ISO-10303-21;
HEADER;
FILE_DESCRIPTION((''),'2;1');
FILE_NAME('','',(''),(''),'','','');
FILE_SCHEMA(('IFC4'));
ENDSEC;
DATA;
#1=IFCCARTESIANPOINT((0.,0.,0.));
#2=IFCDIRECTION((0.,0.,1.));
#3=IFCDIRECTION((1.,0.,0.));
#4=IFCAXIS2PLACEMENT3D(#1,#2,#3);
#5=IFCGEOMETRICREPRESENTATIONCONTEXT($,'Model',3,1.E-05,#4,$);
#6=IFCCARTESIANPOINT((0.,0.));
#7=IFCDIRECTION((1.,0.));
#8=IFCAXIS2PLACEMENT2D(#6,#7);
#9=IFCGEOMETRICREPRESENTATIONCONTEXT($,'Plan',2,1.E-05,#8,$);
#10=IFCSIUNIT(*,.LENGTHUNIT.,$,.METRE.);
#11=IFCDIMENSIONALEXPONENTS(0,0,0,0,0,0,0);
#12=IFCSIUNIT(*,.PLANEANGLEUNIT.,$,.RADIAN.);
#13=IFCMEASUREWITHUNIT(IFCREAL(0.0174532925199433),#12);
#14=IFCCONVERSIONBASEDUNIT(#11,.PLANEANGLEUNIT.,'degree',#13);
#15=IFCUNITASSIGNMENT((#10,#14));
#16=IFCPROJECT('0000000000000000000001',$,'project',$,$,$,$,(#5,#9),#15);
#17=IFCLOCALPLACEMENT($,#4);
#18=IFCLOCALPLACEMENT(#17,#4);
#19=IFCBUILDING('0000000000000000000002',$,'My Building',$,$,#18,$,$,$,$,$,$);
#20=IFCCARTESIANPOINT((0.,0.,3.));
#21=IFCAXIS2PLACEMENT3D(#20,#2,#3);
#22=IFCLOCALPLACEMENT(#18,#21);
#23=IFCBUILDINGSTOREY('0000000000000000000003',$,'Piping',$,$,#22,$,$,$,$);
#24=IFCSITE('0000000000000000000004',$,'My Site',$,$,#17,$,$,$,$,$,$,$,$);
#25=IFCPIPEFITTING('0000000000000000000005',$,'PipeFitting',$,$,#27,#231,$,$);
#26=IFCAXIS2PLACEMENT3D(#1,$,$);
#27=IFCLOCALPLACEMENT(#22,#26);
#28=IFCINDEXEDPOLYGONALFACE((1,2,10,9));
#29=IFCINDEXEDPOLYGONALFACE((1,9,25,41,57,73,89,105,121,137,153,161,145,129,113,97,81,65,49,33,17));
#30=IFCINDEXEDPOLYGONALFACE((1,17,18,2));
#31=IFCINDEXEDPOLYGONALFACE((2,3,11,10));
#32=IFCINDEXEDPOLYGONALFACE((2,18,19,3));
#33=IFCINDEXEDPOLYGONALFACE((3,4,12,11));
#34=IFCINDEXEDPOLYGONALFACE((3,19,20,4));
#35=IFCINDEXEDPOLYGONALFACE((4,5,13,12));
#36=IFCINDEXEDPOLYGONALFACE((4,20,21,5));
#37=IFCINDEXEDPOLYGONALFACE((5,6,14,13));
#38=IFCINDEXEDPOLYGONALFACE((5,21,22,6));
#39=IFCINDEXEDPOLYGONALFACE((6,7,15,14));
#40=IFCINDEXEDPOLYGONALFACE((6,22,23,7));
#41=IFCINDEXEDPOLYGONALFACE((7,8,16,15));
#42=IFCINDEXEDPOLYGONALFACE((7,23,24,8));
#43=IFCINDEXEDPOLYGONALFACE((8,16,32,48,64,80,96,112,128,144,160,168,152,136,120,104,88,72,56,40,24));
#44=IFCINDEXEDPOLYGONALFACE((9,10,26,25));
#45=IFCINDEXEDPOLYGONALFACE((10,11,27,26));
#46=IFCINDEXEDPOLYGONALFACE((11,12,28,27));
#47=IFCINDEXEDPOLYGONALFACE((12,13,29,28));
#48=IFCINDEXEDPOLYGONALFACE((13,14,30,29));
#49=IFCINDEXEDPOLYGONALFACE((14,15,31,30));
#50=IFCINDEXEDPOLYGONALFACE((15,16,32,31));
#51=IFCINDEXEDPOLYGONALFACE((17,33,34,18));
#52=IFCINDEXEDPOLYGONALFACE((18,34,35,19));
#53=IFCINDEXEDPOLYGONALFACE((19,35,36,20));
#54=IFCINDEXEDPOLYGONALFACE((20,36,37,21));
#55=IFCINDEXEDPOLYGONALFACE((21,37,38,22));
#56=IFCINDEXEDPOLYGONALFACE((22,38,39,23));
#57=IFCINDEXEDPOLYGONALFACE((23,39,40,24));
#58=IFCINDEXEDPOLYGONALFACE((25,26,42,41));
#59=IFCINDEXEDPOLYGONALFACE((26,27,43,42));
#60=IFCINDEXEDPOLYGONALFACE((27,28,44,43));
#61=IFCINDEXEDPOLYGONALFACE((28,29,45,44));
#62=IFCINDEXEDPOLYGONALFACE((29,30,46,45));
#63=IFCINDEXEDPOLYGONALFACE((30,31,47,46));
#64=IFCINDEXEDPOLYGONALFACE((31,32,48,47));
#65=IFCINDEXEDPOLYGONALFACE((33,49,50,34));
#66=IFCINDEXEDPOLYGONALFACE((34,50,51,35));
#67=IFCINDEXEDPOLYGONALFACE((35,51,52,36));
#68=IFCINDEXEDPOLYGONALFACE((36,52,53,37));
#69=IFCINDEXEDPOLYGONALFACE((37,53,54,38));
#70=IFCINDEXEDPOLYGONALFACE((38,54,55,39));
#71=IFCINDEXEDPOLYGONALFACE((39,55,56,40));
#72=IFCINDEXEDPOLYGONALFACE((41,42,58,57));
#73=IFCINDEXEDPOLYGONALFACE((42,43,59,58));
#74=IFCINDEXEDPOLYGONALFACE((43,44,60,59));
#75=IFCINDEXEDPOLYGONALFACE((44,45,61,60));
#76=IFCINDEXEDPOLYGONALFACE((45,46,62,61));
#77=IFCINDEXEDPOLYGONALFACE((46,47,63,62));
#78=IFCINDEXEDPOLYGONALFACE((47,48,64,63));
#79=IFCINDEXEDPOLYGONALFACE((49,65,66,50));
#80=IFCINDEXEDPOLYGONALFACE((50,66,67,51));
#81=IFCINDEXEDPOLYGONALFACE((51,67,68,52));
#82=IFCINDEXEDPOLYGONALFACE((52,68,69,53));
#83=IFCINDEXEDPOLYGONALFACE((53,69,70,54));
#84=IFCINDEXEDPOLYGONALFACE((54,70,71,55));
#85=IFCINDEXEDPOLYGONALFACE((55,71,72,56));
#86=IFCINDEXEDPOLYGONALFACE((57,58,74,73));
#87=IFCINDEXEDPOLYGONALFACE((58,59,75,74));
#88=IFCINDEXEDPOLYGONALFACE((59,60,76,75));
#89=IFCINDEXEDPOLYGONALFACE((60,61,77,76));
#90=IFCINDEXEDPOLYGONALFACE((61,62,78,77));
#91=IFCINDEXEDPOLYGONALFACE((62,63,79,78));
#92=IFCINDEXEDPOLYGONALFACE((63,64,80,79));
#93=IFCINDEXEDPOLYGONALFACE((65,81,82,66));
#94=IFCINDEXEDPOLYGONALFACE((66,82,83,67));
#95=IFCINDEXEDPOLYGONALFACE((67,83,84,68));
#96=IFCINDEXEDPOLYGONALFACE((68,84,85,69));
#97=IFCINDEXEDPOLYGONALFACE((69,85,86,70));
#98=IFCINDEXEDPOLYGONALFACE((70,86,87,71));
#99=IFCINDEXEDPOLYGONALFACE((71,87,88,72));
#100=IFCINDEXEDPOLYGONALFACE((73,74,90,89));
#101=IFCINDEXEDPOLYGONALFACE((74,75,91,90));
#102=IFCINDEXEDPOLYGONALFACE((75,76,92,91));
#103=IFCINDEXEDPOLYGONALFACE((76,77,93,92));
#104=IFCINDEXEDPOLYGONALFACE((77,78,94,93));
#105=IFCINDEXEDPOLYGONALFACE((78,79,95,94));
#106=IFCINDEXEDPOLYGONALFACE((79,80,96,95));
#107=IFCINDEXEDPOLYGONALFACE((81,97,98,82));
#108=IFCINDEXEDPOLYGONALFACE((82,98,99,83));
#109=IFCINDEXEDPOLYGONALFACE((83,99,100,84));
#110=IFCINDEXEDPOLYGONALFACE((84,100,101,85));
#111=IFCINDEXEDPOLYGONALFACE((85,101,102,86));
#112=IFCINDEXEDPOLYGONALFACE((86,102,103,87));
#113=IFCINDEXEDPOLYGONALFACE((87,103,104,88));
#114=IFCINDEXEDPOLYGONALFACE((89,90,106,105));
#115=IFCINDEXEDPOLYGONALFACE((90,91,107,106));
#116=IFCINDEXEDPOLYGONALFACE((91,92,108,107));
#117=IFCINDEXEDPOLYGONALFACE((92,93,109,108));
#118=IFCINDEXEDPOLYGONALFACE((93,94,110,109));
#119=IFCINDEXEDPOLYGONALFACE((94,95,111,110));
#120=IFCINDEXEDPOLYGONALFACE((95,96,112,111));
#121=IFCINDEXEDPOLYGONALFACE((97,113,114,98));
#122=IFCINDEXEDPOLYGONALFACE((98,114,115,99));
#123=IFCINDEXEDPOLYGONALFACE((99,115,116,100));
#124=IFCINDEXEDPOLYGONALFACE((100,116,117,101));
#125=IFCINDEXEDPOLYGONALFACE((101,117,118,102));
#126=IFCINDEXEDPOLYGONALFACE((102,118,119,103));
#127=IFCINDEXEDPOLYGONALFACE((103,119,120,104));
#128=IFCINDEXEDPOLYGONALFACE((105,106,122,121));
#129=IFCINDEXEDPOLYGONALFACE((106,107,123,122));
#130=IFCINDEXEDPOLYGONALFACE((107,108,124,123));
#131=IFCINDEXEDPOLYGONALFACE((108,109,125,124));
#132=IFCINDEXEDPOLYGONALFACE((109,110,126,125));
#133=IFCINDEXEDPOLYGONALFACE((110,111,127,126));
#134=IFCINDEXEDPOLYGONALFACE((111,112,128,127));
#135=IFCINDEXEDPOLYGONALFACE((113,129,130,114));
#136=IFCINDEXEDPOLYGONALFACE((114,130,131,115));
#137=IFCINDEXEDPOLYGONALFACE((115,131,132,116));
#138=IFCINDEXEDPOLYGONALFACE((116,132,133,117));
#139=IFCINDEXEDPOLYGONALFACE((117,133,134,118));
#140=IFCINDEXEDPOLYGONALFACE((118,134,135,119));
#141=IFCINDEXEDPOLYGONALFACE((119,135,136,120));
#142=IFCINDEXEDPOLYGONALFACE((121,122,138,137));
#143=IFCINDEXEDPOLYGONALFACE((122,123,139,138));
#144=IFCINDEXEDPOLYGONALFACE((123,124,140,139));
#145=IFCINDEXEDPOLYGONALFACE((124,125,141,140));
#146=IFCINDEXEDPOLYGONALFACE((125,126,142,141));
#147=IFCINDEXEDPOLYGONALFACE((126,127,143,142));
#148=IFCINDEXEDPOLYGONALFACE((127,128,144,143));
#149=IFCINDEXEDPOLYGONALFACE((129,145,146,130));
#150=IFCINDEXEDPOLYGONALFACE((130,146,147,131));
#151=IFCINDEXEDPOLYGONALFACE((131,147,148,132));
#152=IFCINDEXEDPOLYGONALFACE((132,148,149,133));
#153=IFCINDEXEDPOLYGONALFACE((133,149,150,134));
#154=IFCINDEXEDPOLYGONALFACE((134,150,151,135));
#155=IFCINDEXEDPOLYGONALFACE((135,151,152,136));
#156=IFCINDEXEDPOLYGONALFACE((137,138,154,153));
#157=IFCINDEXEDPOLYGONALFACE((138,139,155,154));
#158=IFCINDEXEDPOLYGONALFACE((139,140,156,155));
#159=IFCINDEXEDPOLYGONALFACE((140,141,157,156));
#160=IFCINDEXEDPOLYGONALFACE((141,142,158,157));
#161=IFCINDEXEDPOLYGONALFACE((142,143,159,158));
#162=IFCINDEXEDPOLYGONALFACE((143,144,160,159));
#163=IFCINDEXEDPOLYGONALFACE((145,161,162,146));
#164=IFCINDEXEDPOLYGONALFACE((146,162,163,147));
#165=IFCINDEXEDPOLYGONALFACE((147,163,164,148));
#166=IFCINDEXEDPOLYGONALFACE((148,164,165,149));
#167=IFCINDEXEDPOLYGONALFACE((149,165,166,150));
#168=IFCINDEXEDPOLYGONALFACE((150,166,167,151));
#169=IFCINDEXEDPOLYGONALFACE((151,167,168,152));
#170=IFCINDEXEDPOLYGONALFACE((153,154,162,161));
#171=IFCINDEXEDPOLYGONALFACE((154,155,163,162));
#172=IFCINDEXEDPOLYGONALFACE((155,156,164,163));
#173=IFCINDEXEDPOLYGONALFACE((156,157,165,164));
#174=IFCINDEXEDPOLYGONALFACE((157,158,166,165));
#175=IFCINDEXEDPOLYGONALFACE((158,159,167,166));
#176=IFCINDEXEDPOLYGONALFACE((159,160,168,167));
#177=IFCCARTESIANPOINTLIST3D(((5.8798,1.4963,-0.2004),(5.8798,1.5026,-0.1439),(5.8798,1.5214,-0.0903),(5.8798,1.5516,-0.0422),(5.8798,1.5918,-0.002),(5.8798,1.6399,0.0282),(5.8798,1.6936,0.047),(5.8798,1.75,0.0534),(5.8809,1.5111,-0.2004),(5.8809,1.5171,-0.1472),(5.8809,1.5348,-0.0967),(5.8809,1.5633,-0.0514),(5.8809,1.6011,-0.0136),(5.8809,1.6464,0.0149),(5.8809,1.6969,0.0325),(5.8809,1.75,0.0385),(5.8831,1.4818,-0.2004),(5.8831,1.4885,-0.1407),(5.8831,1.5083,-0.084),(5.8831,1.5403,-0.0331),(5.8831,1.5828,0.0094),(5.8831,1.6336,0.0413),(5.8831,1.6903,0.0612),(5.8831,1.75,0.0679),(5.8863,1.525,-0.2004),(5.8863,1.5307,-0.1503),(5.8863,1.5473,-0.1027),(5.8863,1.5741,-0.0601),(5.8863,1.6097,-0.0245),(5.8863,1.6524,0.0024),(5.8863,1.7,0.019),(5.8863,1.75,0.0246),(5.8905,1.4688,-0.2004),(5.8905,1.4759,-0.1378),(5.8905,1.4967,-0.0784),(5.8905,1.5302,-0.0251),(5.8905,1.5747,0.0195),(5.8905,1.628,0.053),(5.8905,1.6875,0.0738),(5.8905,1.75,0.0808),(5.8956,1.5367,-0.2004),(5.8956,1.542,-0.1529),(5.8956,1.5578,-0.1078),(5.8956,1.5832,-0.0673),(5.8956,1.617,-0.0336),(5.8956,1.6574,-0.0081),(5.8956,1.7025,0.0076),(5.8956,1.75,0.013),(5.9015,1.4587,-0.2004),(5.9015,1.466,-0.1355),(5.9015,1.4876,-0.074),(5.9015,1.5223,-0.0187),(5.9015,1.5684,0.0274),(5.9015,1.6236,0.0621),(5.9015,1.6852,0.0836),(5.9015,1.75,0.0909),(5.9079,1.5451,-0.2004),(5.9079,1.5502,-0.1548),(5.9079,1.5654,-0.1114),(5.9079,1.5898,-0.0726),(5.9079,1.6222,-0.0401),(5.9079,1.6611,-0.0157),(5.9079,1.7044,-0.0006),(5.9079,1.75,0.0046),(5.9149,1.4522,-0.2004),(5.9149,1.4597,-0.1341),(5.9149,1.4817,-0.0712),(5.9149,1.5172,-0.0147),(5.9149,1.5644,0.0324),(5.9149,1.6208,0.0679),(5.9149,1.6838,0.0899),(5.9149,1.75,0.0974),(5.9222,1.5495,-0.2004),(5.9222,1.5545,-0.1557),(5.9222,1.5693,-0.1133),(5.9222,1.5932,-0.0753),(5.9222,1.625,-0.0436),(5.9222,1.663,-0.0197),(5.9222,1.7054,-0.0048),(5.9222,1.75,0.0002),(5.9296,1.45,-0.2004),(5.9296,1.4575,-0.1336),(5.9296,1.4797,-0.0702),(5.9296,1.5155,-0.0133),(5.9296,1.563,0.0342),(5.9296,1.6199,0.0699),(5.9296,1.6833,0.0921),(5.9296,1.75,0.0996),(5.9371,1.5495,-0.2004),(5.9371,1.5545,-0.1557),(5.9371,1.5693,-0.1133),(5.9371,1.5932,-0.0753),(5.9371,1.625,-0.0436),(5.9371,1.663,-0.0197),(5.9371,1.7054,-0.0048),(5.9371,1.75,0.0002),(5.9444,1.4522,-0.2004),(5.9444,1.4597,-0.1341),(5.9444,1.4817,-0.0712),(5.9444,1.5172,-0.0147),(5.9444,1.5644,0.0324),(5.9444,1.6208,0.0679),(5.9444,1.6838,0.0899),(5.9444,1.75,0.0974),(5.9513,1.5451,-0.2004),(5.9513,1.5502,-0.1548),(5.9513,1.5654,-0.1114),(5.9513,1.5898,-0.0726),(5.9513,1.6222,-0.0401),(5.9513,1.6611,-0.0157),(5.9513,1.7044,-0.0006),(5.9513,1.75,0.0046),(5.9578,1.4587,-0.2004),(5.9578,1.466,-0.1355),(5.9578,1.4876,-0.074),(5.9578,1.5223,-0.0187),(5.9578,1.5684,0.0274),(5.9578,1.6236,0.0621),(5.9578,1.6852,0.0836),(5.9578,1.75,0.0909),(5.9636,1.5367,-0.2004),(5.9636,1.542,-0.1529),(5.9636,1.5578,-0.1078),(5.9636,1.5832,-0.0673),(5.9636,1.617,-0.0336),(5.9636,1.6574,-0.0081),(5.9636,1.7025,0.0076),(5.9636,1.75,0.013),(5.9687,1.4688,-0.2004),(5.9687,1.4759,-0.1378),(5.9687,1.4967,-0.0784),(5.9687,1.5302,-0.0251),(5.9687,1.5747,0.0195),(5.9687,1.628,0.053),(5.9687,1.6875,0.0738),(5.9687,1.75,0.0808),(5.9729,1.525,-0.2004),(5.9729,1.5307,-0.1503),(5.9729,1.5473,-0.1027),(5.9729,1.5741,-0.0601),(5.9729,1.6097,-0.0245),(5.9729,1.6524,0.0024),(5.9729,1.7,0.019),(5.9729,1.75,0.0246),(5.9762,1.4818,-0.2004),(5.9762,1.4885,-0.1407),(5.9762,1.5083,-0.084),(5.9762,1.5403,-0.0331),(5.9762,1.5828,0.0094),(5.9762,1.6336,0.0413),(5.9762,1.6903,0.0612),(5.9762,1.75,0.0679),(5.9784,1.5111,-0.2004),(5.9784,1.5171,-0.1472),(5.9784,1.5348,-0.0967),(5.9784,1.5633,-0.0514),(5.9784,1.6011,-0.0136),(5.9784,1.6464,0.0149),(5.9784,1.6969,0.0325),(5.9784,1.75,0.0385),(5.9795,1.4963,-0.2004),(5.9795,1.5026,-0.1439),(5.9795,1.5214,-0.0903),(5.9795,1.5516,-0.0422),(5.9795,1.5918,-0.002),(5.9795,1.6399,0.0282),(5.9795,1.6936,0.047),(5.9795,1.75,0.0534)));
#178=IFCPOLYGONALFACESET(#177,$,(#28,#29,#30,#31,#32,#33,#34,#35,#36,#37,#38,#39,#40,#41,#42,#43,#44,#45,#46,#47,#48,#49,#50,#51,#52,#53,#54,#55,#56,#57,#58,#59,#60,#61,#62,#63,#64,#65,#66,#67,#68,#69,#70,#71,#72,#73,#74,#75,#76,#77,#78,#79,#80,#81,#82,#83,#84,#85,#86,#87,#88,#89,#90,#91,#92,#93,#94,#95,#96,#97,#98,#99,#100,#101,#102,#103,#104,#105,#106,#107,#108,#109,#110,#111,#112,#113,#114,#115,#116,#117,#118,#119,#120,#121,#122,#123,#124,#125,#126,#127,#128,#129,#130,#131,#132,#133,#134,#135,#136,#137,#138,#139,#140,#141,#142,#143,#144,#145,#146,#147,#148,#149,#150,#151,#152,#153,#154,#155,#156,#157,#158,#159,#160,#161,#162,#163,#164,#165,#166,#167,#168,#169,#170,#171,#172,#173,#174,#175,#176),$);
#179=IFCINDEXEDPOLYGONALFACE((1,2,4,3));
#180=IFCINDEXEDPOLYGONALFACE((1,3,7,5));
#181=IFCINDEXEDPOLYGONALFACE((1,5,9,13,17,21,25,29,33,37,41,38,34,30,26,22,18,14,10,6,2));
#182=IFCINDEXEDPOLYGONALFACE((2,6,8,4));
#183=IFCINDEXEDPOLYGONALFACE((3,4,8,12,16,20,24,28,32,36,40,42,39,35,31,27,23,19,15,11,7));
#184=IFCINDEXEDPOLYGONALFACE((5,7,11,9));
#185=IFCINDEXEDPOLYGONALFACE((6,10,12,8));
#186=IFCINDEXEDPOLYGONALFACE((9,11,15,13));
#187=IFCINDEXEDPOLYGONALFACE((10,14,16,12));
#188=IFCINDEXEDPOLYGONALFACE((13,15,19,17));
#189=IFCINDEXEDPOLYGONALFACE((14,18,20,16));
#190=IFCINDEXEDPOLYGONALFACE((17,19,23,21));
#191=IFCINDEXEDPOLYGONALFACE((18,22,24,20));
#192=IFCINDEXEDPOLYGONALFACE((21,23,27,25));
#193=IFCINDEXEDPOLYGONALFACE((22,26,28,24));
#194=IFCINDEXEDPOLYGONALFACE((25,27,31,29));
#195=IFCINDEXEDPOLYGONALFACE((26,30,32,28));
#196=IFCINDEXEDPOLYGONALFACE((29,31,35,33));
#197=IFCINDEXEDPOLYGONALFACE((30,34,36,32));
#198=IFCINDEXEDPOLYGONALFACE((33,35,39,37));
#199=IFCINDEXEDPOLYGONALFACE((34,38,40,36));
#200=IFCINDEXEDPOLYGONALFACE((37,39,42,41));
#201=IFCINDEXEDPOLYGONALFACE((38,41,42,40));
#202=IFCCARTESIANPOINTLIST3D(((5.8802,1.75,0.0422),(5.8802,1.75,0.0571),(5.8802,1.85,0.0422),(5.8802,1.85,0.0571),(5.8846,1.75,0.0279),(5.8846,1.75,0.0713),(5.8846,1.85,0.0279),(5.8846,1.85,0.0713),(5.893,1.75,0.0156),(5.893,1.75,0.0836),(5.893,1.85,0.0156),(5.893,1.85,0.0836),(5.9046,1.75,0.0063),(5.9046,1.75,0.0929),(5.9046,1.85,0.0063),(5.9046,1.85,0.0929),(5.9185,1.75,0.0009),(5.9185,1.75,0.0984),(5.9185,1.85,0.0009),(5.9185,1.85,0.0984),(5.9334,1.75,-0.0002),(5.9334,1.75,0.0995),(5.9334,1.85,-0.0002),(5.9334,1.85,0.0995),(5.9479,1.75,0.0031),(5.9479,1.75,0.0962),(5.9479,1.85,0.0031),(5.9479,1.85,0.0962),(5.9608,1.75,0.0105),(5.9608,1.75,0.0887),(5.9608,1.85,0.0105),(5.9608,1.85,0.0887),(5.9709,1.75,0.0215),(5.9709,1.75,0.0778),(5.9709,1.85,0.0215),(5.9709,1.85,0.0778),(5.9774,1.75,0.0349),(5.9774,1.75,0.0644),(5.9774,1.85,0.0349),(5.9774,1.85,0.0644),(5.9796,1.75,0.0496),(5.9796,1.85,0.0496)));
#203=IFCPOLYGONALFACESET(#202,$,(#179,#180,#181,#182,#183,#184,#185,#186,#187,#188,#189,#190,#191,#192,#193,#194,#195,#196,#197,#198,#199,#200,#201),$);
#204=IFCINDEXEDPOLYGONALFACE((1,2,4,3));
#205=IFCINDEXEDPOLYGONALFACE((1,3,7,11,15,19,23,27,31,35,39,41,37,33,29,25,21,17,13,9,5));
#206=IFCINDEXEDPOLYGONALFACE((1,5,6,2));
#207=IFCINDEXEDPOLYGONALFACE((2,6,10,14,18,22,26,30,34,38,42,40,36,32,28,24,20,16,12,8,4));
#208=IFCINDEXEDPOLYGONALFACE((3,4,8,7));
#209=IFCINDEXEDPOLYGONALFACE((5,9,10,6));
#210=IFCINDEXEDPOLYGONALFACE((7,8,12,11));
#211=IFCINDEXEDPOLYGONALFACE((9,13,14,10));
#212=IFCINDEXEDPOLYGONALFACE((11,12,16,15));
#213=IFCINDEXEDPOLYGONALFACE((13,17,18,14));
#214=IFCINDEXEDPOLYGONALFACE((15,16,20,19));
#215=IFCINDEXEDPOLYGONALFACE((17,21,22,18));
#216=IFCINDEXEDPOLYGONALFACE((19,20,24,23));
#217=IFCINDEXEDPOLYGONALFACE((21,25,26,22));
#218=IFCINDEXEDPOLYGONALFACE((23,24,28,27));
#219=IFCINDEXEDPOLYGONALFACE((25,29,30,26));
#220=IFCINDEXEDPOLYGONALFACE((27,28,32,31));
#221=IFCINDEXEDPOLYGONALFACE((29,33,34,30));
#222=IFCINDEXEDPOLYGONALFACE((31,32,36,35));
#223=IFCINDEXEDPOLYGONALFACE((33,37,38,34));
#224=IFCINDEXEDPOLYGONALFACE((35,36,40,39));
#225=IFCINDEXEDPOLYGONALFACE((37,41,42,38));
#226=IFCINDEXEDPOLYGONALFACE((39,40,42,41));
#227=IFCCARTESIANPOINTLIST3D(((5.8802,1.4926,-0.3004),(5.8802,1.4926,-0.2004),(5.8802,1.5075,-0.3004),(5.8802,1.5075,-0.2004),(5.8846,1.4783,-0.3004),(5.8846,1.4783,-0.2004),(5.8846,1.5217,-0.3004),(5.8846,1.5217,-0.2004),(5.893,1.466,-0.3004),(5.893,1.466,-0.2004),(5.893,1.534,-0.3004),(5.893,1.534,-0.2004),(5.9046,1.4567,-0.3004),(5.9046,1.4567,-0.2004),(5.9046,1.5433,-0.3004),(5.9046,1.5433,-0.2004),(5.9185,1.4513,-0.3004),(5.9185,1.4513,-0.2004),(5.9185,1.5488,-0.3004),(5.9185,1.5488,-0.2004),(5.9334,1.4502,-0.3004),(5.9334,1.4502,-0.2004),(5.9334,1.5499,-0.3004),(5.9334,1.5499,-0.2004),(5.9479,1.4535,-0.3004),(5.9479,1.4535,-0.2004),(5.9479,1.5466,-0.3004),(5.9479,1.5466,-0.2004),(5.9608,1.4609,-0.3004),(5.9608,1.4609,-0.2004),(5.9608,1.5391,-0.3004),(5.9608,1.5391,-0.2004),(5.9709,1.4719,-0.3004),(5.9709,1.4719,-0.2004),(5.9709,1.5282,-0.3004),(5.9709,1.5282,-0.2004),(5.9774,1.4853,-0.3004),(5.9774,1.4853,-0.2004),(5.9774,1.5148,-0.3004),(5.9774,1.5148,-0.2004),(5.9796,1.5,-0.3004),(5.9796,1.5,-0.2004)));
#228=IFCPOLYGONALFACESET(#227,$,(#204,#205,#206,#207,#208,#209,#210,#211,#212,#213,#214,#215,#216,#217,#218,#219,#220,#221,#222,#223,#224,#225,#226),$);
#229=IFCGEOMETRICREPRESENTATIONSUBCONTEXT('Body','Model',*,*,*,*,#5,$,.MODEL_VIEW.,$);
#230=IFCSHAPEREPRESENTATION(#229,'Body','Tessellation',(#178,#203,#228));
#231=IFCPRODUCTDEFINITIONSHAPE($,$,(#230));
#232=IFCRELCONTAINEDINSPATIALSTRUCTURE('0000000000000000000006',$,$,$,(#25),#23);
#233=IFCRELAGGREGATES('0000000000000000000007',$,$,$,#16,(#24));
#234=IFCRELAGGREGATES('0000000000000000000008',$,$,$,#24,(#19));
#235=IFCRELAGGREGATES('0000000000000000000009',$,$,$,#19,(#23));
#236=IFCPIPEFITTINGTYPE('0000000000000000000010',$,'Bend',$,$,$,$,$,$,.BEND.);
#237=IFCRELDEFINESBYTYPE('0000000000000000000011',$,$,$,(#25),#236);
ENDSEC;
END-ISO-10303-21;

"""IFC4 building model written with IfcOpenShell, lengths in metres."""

from ifc_helpers import new_model, entity, si_unit, converted_unit, frame, origin_with_axes, origin_2d_with_axis, place, context, subcontext, project, spatial, circle, extrude, source, transform, mapped, type_object, type_shapes, element, save


model = new_model("IFC4")

# Units and contexts
model_context = context("Model", 3, precision=1e-05, world=origin_with_axes())
plan_context = context("Plan", 2, precision=1e-05, world=origin_2d_with_axis())
body_context = subcontext(model_context, "Body", "Model", "MODEL_VIEW")
ifc_project = project(units=[si_unit("LENGTHUNIT", "METRE"), converted_unit("PLANEANGLEUNIT", "degree", entity("IfcReal", 0.0174532925199433), si_unit("PLANEANGLEUNIT", "RADIAN"), dimensions=[0, 0, 0, 0, 0, 0, 0])], contexts=[model_context, plan_context])

# Site, building, storey
site_placement = place(None, origin_with_axes())
site = spatial("IfcSite", under=ifc_project, at=site_placement, Name="My Site")
building_placement = place(site_placement, origin_with_axes())
building = spatial("IfcBuilding", under=site, at=building_placement, Name="My Building")
storey_placement = place(building_placement, frame((0.0, 0.0, 3.0), z_axis=(0.0, 0.0, 1.0), x_axis=(1.0, 0.0, 0.0)))
storey = spatial("IfcBuildingStorey", under=building, at=storey_placement, Name="Piping")

# Pipe fitting
pipe_fitting_type_1 = type_object("IfcPipeFittingType", Name="Bend", PredefinedType="BEND")
shared_shape = source(origin_with_axes(), body_context, "Body", "SolidModel", [
    entity("IfcSweptDiskSolid", entity("IfcIndexedPolyCurve", entity("IfcCartesianPointList3D", [[0.0, 0.0, 0.1], [0.0, -0.0732, 0.2768], [0.0, -0.25, 0.35]]), [entity("IfcArcIndex", [1, 2, 3])]), 0.05),
    extrude(circle(Radius=0.05), origin_with_axes(), (0.0, 0.0, 1.0), 0.1),
    extrude(circle(Radius=0.05), frame((0.0, -0.25, 0.35), z_axis=(0.0, -1.0, 0.0), x_axis=(1.0, 0.0, 0.0)), (0.0, 0.0, 1.0), 0.1),
])
type_shapes(pipe_fitting_type_1, [shared_shape])
for number, where, z_axis, x_axis, name in (
    (1, (5.9296, 1.85, 0.0496), (0.0, -1.0, 0.0), (1.0, 0.0, 0.0), "PipeFitting"),
):
    element("IfcPipeFitting", number, at=place(storey_placement, frame(where, z_axis=z_axis, x_axis=x_axis)), inside=storey, type_object=pipe_fitting_type_1, Name=name, context=body_context, shape_type="MappedRepresentation", body=[
        mapped(shared_shape, transform((0.0, 0.0, 0.0), x_axis=(1.0, 0.0, 0.0), y_axis=(0.0, 1.0, 0.0), z_axis=(0.0, 0.0, 1.0), scale=1.0)),
    ])

save(model, "model.ifc")
